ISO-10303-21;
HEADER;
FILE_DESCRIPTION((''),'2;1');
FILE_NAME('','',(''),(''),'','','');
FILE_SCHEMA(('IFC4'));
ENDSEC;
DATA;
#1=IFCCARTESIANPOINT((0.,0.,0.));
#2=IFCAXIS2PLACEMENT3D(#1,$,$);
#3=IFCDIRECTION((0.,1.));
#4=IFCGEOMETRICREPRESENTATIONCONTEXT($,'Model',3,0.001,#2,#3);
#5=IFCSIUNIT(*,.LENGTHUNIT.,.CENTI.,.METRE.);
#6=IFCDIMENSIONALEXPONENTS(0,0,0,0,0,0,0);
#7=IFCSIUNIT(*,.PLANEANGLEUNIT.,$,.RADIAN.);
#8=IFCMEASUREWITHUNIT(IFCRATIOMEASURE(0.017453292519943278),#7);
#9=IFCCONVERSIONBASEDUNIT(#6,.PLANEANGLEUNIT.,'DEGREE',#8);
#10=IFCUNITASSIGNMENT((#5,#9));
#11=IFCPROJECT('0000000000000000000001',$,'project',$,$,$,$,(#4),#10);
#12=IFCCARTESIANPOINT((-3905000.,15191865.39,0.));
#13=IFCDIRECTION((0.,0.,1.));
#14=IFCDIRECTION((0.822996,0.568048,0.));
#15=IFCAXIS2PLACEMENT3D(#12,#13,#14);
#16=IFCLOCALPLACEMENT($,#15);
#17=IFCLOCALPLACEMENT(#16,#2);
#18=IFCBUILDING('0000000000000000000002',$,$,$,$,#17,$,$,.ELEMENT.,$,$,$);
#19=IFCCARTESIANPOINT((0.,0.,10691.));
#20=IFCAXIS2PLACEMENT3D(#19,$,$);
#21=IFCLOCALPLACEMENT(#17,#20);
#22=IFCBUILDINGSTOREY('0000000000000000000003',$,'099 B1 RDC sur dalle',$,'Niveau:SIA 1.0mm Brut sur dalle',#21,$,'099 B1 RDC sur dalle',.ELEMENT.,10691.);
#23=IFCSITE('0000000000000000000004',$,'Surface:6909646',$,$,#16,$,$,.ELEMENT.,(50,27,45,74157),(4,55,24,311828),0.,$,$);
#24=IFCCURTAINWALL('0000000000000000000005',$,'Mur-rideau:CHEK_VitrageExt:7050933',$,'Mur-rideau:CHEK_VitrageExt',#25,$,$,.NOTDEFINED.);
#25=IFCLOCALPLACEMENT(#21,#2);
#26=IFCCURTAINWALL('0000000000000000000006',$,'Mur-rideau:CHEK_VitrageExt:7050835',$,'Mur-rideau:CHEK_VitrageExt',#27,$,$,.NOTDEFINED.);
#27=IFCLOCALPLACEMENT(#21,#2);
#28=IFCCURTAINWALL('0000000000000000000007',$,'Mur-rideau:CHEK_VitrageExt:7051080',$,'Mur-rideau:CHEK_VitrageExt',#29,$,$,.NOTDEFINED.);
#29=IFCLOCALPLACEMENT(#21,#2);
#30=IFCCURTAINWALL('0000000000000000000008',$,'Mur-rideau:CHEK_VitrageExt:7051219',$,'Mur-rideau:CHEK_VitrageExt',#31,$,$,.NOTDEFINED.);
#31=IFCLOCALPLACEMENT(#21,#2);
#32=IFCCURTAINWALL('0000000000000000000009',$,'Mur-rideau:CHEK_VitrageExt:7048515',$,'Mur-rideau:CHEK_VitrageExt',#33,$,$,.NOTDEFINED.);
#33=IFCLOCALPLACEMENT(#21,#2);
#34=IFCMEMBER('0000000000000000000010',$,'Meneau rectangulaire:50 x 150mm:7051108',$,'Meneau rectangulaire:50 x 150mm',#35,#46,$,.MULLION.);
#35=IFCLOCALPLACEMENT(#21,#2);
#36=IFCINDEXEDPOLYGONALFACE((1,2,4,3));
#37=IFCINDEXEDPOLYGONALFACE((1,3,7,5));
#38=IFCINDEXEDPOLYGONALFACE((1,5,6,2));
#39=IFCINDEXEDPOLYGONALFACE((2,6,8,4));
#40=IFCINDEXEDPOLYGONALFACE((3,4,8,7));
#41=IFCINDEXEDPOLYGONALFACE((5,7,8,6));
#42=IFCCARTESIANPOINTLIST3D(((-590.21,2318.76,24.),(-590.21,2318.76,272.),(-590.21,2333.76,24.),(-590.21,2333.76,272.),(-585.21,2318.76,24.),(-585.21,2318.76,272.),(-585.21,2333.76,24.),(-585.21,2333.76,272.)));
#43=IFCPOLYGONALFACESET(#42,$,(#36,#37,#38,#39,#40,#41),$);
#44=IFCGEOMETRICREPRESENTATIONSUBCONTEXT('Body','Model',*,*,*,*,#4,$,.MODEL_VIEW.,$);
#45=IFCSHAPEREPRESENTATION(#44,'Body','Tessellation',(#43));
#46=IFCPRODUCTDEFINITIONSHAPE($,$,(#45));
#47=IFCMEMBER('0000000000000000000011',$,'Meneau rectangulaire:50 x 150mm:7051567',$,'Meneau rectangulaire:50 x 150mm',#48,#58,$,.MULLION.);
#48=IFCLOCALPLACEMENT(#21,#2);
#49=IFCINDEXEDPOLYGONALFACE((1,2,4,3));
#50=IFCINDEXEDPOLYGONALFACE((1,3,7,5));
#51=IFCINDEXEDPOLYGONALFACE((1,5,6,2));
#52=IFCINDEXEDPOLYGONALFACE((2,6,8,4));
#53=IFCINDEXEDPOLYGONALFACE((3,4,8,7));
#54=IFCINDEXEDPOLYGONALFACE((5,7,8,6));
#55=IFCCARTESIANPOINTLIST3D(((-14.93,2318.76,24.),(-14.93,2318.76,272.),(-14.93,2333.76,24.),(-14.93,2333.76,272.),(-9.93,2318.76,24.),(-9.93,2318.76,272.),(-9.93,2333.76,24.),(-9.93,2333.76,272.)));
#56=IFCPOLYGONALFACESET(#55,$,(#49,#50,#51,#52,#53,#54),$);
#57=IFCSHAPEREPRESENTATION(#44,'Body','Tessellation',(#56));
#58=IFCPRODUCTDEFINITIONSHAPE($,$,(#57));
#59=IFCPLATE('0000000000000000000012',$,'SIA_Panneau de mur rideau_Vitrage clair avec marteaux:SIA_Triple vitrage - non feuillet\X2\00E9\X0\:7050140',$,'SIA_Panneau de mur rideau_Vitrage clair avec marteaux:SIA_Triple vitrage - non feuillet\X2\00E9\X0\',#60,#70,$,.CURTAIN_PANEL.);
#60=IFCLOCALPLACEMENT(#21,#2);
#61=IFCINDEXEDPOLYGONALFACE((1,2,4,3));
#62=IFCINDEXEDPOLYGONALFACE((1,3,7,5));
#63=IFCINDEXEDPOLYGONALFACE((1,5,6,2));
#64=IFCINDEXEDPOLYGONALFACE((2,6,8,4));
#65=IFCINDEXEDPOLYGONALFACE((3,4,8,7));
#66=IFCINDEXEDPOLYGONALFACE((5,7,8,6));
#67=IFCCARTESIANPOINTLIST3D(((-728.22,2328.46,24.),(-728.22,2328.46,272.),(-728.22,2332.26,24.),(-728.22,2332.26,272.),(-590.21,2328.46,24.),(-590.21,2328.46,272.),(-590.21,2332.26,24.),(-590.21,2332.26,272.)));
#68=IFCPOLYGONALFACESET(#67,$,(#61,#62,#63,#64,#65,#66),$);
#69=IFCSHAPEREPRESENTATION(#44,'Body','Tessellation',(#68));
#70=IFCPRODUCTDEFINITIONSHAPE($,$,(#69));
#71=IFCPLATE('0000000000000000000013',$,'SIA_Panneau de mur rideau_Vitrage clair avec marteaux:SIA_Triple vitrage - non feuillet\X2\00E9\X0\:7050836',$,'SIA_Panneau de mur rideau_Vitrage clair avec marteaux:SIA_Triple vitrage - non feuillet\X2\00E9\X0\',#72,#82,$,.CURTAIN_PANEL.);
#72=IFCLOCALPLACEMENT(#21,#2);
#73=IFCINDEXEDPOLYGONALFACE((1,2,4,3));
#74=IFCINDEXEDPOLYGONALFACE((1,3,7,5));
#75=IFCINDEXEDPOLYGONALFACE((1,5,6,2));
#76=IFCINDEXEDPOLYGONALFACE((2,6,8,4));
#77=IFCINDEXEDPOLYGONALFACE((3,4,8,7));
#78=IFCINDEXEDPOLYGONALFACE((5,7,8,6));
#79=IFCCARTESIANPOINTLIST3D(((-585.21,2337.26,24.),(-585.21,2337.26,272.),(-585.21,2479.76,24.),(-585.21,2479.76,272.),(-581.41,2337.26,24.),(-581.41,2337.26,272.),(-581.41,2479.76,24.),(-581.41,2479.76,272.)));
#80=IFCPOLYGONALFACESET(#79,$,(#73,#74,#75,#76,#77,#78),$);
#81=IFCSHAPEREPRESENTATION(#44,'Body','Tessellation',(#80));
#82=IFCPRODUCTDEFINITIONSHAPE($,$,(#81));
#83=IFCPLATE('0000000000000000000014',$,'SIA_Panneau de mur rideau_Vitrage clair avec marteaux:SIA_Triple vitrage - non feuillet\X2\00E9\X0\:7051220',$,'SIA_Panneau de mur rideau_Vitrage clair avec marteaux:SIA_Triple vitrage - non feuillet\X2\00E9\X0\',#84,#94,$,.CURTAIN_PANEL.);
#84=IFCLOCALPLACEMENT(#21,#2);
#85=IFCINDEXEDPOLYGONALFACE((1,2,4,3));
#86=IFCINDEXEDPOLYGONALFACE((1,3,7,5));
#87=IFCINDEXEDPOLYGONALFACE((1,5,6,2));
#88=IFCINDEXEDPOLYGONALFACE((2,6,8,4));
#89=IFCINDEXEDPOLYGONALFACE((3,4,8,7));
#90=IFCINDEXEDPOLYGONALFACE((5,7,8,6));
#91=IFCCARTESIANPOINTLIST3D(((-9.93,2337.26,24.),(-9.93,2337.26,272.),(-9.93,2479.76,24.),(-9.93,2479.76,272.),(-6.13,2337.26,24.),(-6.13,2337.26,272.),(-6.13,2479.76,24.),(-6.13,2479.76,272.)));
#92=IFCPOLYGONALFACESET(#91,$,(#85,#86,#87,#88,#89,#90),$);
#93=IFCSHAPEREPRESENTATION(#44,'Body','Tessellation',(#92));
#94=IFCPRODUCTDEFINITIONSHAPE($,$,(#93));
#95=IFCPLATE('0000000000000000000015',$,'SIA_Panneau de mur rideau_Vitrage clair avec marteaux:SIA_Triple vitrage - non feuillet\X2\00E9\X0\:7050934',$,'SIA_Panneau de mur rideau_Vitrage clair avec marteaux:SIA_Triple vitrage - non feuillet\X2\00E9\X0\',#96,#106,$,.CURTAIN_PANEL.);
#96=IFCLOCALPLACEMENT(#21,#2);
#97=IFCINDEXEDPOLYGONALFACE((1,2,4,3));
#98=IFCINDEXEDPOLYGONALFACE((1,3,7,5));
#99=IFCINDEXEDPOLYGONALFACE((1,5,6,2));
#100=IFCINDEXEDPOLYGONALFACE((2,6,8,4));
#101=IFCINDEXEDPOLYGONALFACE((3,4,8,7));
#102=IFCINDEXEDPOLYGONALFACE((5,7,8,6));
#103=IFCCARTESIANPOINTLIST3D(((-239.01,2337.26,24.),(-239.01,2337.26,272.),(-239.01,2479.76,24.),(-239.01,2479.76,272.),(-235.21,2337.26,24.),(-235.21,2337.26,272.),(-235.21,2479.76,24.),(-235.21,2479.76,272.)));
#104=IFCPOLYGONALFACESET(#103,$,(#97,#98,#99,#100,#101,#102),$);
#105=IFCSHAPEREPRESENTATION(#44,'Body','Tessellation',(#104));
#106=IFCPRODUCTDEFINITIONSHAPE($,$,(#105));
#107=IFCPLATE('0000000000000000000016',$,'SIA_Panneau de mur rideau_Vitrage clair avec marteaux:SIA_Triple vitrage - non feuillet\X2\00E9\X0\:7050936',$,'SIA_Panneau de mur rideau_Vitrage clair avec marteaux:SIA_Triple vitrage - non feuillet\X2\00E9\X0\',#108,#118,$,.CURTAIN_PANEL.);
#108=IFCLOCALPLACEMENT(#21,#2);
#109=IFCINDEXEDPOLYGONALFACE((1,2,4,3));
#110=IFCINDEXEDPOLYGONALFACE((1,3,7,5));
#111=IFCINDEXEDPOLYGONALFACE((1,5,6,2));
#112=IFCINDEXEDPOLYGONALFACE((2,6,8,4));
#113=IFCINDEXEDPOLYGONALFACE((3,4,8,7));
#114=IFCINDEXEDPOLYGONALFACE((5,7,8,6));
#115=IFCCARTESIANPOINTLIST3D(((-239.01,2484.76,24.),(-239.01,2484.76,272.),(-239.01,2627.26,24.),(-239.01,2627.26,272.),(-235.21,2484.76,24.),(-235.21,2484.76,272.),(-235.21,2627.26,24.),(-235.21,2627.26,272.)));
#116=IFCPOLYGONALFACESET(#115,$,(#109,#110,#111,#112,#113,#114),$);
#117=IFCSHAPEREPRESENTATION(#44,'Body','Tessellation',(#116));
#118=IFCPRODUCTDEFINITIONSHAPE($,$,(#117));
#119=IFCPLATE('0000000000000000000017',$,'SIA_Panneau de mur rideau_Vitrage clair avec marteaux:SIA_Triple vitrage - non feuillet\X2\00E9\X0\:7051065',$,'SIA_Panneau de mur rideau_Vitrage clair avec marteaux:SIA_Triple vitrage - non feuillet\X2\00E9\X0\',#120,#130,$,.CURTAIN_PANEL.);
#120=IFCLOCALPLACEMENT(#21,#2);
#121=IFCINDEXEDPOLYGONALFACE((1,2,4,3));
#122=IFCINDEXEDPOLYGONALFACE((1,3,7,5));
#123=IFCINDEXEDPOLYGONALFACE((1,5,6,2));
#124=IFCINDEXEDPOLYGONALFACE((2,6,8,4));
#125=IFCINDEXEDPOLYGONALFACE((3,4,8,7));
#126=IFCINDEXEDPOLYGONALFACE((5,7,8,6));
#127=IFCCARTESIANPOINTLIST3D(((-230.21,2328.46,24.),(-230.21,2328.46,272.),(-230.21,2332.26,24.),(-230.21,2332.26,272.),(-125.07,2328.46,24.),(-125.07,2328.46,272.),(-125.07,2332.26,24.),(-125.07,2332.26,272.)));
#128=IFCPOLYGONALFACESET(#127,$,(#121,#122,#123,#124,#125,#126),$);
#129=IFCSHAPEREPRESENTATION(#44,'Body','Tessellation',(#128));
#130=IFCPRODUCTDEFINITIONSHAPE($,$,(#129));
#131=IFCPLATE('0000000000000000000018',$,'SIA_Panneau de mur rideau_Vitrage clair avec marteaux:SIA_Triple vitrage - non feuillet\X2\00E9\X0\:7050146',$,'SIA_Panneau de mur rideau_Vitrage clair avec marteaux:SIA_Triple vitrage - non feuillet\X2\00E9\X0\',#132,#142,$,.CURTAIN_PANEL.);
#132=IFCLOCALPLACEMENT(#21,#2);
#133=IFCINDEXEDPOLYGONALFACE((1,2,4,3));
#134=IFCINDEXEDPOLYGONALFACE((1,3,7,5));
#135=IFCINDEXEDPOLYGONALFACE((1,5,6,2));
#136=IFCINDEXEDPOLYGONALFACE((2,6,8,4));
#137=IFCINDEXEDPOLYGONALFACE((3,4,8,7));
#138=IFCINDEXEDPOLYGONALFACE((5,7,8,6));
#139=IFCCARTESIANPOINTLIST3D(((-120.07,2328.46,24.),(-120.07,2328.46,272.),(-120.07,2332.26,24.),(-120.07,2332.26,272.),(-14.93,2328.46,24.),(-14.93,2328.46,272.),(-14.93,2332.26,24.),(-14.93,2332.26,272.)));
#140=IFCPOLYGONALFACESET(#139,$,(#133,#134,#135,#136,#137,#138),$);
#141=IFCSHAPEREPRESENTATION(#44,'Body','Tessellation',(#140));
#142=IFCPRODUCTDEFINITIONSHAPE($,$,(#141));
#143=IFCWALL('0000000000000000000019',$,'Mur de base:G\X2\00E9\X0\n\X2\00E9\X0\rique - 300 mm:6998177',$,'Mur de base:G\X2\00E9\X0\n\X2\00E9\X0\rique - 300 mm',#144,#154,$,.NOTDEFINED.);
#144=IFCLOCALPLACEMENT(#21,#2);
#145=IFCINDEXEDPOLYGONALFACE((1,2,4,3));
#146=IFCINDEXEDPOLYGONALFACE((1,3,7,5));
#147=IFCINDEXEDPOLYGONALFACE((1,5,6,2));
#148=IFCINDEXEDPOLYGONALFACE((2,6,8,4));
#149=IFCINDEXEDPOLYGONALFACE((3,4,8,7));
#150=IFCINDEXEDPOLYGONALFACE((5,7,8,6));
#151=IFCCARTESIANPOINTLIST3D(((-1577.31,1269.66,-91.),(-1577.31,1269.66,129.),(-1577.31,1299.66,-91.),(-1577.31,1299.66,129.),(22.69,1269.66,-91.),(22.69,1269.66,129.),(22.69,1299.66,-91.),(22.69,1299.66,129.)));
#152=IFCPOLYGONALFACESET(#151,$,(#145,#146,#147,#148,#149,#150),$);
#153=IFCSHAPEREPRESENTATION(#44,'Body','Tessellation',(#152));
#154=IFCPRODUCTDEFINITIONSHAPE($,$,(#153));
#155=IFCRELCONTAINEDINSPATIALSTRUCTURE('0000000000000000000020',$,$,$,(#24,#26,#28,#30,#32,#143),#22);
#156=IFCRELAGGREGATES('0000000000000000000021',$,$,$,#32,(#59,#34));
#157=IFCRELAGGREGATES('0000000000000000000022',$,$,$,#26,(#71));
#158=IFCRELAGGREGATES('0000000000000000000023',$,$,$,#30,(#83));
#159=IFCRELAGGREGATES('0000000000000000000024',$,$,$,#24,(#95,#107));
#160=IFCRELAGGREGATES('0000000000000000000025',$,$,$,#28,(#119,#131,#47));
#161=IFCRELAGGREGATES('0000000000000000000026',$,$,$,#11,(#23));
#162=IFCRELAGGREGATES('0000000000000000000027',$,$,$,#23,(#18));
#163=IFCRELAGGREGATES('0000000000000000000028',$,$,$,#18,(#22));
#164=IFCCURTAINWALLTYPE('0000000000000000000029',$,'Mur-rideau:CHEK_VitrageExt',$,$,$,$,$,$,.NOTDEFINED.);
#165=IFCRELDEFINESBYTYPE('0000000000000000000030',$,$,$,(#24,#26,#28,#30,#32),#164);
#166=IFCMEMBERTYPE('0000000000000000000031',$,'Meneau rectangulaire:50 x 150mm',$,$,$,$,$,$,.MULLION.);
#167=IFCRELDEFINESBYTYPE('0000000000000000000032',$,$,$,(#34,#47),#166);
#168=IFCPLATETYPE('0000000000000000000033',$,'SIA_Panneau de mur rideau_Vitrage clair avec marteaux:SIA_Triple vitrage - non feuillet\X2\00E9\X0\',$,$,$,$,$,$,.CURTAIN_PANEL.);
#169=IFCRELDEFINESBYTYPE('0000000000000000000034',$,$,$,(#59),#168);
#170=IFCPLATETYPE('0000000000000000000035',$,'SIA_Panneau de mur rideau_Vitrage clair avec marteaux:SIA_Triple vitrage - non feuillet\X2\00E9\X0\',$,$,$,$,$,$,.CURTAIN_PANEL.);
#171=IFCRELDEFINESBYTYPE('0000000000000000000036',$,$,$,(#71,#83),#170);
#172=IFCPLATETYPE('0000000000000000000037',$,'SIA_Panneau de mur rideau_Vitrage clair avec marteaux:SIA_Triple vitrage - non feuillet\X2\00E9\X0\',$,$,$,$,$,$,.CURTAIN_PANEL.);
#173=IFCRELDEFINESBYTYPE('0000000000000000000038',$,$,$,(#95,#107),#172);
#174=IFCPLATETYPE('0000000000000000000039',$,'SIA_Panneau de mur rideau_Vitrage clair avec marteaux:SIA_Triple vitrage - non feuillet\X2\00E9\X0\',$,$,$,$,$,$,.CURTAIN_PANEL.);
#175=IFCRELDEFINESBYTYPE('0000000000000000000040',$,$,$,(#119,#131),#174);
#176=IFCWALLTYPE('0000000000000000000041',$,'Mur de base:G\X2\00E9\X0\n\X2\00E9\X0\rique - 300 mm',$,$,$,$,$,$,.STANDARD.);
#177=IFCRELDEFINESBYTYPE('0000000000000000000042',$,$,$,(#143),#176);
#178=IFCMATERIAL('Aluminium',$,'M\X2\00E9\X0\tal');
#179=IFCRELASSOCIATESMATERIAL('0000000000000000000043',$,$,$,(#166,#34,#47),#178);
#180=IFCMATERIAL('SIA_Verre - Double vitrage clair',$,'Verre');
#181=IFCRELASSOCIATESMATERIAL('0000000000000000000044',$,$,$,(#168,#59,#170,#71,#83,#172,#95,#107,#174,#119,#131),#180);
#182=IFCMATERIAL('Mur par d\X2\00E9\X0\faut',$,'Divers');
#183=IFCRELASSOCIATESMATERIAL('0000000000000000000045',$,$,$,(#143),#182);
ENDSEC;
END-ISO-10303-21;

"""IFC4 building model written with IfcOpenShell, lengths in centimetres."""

from ifc_helpers import new_model, entity, si_unit, converted_unit, direction, frame, origin, place, context, subcontext, project, spatial, indexed_curve, outline, extrude, source, transform, mapped, material, type_object, type_shapes, element, aggregate, save


model = new_model("IFC4")

# Units and contexts
model_context = context("Model", 3, precision=0.001, world=origin(), true_north=direction((0.0, 1.0)))
body_context = subcontext(model_context, "Body", "Model", "MODEL_VIEW")
ifc_project = project(units=[si_unit("LENGTHUNIT", "METRE", prefix="CENTI"), converted_unit("PLANEANGLEUNIT", "DEGREE", entity("IfcRatioMeasure", 0.017453292519943278), si_unit("PLANEANGLEUNIT", "RADIAN"), dimensions=[0, 0, 0, 0, 0, 0, 0])], contexts=[model_context])

# Site, building, storey
site_placement = place(None, frame((-3905000.0, 15191865.39, 0.0), z_axis=(0.0, 0.0, 1.0), x_axis=(0.822996, 0.568048, 0.0)))
site = spatial("IfcSite", under=ifc_project, at=site_placement, Name="Surface:6909646", CompositionType="ELEMENT", RefLatitude=(50, 27, 45, 74157), RefLongitude=(4, 55, 24, 311828), RefElevation=0.0)
building_placement = place(site_placement, origin())
building = spatial("IfcBuilding", under=site, at=building_placement, CompositionType="ELEMENT")
storey_placement = place(building_placement, frame((0.0, 0.0, 10691.0)))
storey = spatial("IfcBuildingStorey", under=building, at=storey_placement, Name="099 B1 RDC sur dalle", ObjectType="Niveau:SIA 1.0mm Brut sur dalle", LongName="099 B1 RDC sur dalle", CompositionType="ELEMENT", Elevation=10691.0)

# Curtain wall
curtain_wall_type = type_object("IfcCurtainWallType", Name="Mur-rideau:CHEK_VitrageExt", PredefinedType="NOTDEFINED")
curtain_wall_1_placement = place(storey_placement, frame((0.0, 0.0, -10691.0)))
curtain_wall_1 = element("IfcCurtainWall", 1, at=curtain_wall_1_placement, inside=storey, type_object=curtain_wall_type, Name="Mur-rideau:CHEK_VitrageExt:7050933", ObjectType="Mur-rideau:CHEK_VitrageExt", PredefinedType="NOTDEFINED")
ifc_material_1 = material(Name="Aluminium", Category="Métal")

# Curtain walls
curtain_wall_2_placement = place(storey_placement, frame((0.0, 0.0, -10691.0)))
curtain_wall_2 = element("IfcCurtainWall", 2, at=curtain_wall_2_placement, inside=storey, type_object=curtain_wall_type, Name="Mur-rideau:CHEK_VitrageExt:7050835", ObjectType="Mur-rideau:CHEK_VitrageExt", PredefinedType="NOTDEFINED")
curtain_wall_3_placement = place(storey_placement, frame((0.0, 0.0, -10691.0)))
curtain_wall_3 = element("IfcCurtainWall", 3, at=curtain_wall_3_placement, inside=storey, type_object=curtain_wall_type, Name="Mur-rideau:CHEK_VitrageExt:7051080", ObjectType="Mur-rideau:CHEK_VitrageExt", PredefinedType="NOTDEFINED")
curtain_wall_4_placement = place(storey_placement, frame((0.0, 0.0, -10691.0)))
curtain_wall_4 = element("IfcCurtainWall", 4, at=curtain_wall_4_placement, inside=storey, type_object=curtain_wall_type, Name="Mur-rideau:CHEK_VitrageExt:7051219", ObjectType="Mur-rideau:CHEK_VitrageExt", PredefinedType="NOTDEFINED")

# Curtain wall, member
curtain_wall_5_placement = place(storey_placement, frame((0.0, 0.0, -10691.0)))
curtain_wall_5 = element("IfcCurtainWall", 5, at=curtain_wall_5_placement, inside=storey, type_object=curtain_wall_type, Name="Mur-rideau:CHEK_VitrageExt:7048515", ObjectType="Mur-rideau:CHEK_VitrageExt", PredefinedType="NOTDEFINED")
member_type_1 = type_object("IfcMemberType", Name="Meneau rectangulaire:50 x 150mm", PredefinedType="MULLION", material=ifc_material_1)
shared_shape_1 = source(origin(), body_context, "Body", "SweptSolid", [
    extrude(outline(indexed_curve([(-7.5, -2.5), (7.5, -2.5), (7.5, 2.5), (-7.5, 2.5), (-7.5, -2.5)], self_intersect=False)), frame((-2.5, 6.0, -248.0), z_axis=(0.0, 0.0, 1.0), x_axis=(0.0, -1.0, 0.0)), (0.0, 0.0, 1.0), 248.0),
])
type_shapes(member_type_1, [shared_shape_1])
member_1_placement = place(curtain_wall_5_placement, frame((-585.21, 2332.26, 10715.0), z_axis=(0.0, 0.0, -1.0), x_axis=(1.0, 0.0, 0.0)))
member_1 = element("IfcMember", 6, at=member_1_placement, type_object=member_type_1, material=ifc_material_1, Name="Meneau rectangulaire:50 x 150mm:7051108", ObjectType="Meneau rectangulaire:50 x 150mm", PredefinedType="MULLION", context=body_context, shape_type="MappedRepresentation", body=[
    mapped(shared_shape_1, transform((0.0, 0.0, 0.0), scale=1.0)),
])

# Member
member_2_placement = place(curtain_wall_3_placement, frame((-9.93, 2332.26, 10715.0), z_axis=(0.0, 0.0, -1.0), x_axis=(1.0, 0.0, 0.0)))
member_2 = element("IfcMember", 7, at=member_2_placement, type_object=member_type_1, material=ifc_material_1, Name="Meneau rectangulaire:50 x 150mm:7051567", ObjectType="Meneau rectangulaire:50 x 150mm", PredefinedType="MULLION", context=body_context, shape_type="MappedRepresentation", body=[
    mapped(shared_shape_1, transform((0.0, 0.0, 0.0), scale=1.0)),
])

# Plates
ifc_material_2 = material(Name="SIA_Verre - Double vitrage clair", Category="Verre")
plate_type_1 = type_object("IfcPlateType", Name="SIA_Panneau de mur rideau_Vitrage clair avec marteaux:SIA_Triple vitrage - non feuilleté", PredefinedType="CURTAIN_PANEL", material=ifc_material_2)
shared_shape_2 = source(origin(), body_context, "Body", "SweptSolid", [
    extrude(outline(indexed_curve([(-1.9, -69.0), (1.9, -69.0), (1.9, 69.0), (-1.9, 69.0), (-1.9, -69.0)], self_intersect=False)), frame((0.0, -1.9, 0.0), z_axis=(0.0, 0.0, 1.0), x_axis=(0.0, 1.0, 0.0)), (0.0, 0.0, 1.0), 248.0),
])
type_shapes(plate_type_1, [shared_shape_2])
plate_1_placement = place(curtain_wall_5_placement, frame((-659.21, 2332.26, 10715.0)))
plate_1 = element("IfcPlate", 8, at=plate_1_placement, type_object=plate_type_1, material=ifc_material_2, Name="SIA_Panneau de mur rideau_Vitrage clair avec marteaux:SIA_Triple vitrage - non feuilleté:7050140", ObjectType="SIA_Panneau de mur rideau_Vitrage clair avec marteaux:SIA_Triple vitrage - non feuilleté", PredefinedType="CURTAIN_PANEL", context=body_context, shape_type="MappedRepresentation", body=[
    mapped(shared_shape_2, transform((0.0, 0.0, 0.0), scale=1.0)),
])
aggregate(curtain_wall_5, [plate_1, member_1])
plate_type_2 = type_object("IfcPlateType", Name="SIA_Panneau de mur rideau_Vitrage clair avec marteaux:SIA_Triple vitrage - non feuilleté", PredefinedType="CURTAIN_PANEL", material=ifc_material_2)
shared_shape_3 = source(origin(), body_context, "Body", "SweptSolid", [
    extrude(outline(indexed_curve([(-1.9, -71.25), (1.9, -71.25), (1.9, 71.25), (-1.9, 71.25), (-1.9, -71.25)], self_intersect=False)), frame((0.0, -1.9, 0.0), z_axis=(0.0, 0.0, 1.0), x_axis=(0.0, 1.0, 0.0)), (0.0, 0.0, 1.0), 248.0),
])
type_shapes(plate_type_2, [shared_shape_3])
plate_2_placement = place(curtain_wall_2_placement, frame((-585.21, 2408.51, 10715.0), z_axis=(0.0, 0.0, 1.0), x_axis=(0.0, 1.0, 0.0)))
plate_2 = element("IfcPlate", 9, at=plate_2_placement, type_object=plate_type_2, material=ifc_material_2, Name="SIA_Panneau de mur rideau_Vitrage clair avec marteaux:SIA_Triple vitrage - non feuilleté:7050836", ObjectType="SIA_Panneau de mur rideau_Vitrage clair avec marteaux:SIA_Triple vitrage - non feuilleté", PredefinedType="CURTAIN_PANEL", context=body_context, shape_type="MappedRepresentation", body=[
    mapped(shared_shape_3, transform((0.0, 0.0, 0.0), scale=1.0)),
])
aggregate(curtain_wall_2, [plate_2])
plate_3_placement = place(curtain_wall_4_placement, frame((-9.93, 2408.51, 10715.0), z_axis=(0.0, 0.0, 1.0), x_axis=(0.0, 1.0, 0.0)))
plate_3 = element("IfcPlate", 10, at=plate_3_placement, type_object=plate_type_2, material=ifc_material_2, Name="SIA_Panneau de mur rideau_Vitrage clair avec marteaux:SIA_Triple vitrage - non feuilleté:7051220", ObjectType="SIA_Panneau de mur rideau_Vitrage clair avec marteaux:SIA_Triple vitrage - non feuilleté", PredefinedType="CURTAIN_PANEL", context=body_context, shape_type="MappedRepresentation", body=[
    mapped(shared_shape_3, transform((0.0, 0.0, 0.0), scale=1.0)),
])
aggregate(curtain_wall_4, [plate_3])
plate_type_3 = type_object("IfcPlateType", Name="SIA_Panneau de mur rideau_Vitrage clair avec marteaux:SIA_Triple vitrage - non feuilleté", PredefinedType="CURTAIN_PANEL", material=ifc_material_2)
shared_shape_4 = source(origin(), body_context, "Body", "SweptSolid", [
    extrude(outline(indexed_curve([(-71.25, -1.9), (71.25, -1.9), (71.25, 1.9), (-71.25, 1.9), (-71.25, -1.9)], self_intersect=False)), frame((0.0, 1.9, 0.0), z_axis=(0.0, 0.0, 1.0), x_axis=(-1.0, 0.0, 0.0)), (0.0, 0.0, 1.0), 248.0),
])
type_shapes(plate_type_3, [shared_shape_4])
plate_4_placement = place(curtain_wall_1_placement, frame((-235.21, 2408.51, 10715.0), z_axis=(0.0, 0.0, 1.0), x_axis=(0.0, 1.0, 0.0)))
plate_4 = element("IfcPlate", 11, at=plate_4_placement, type_object=plate_type_3, material=ifc_material_2, Name="SIA_Panneau de mur rideau_Vitrage clair avec marteaux:SIA_Triple vitrage - non feuilleté:7050934", ObjectType="SIA_Panneau de mur rideau_Vitrage clair avec marteaux:SIA_Triple vitrage - non feuilleté", PredefinedType="CURTAIN_PANEL", context=body_context, shape_type="MappedRepresentation", body=[
    mapped(shared_shape_4, transform((0.0, 0.0, 0.0), scale=1.0)),
])
plate_5_placement = place(curtain_wall_1_placement, frame((-235.21, 2556.01, 10715.0), z_axis=(0.0, 0.0, 1.0), x_axis=(0.0, 1.0, 0.0)))
plate_5 = element("IfcPlate", 12, at=plate_5_placement, type_object=plate_type_3, material=ifc_material_2, Name="SIA_Panneau de mur rideau_Vitrage clair avec marteaux:SIA_Triple vitrage - non feuilleté:7050936", ObjectType="SIA_Panneau de mur rideau_Vitrage clair avec marteaux:SIA_Triple vitrage - non feuilleté", PredefinedType="CURTAIN_PANEL", context=body_context, shape_type="MappedRepresentation", body=[
    mapped(shared_shape_4, transform((0.0, 0.0, 0.0), scale=1.0)),
])
aggregate(curtain_wall_1, [plate_4, plate_5])
plate_type_4 = type_object("IfcPlateType", Name="SIA_Panneau de mur rideau_Vitrage clair avec marteaux:SIA_Triple vitrage - non feuilleté", PredefinedType="CURTAIN_PANEL", material=ifc_material_2)
shared_shape_5 = source(origin(), body_context, "Body", "SweptSolid", [
    extrude(outline(indexed_curve([(-1.9, -52.57), (1.9, -52.57), (1.9, 52.57), (-1.9, 52.57), (-1.9, -52.57)], self_intersect=False)), frame((0.0, -1.9, 0.0), z_axis=(0.0, 0.0, 1.0), x_axis=(0.0, 1.0, 0.0)), (0.0, 0.0, 1.0), 248.0),
])
type_shapes(plate_type_4, [shared_shape_5])
plate_6_placement = place(curtain_wall_3_placement, frame((-177.64, 2332.26, 10715.0)))
plate_6 = element("IfcPlate", 13, at=plate_6_placement, type_object=plate_type_4, material=ifc_material_2, Name="SIA_Panneau de mur rideau_Vitrage clair avec marteaux:SIA_Triple vitrage - non feuilleté:7051065", ObjectType="SIA_Panneau de mur rideau_Vitrage clair avec marteaux:SIA_Triple vitrage - non feuilleté", PredefinedType="CURTAIN_PANEL", context=body_context, shape_type="MappedRepresentation", body=[
    mapped(shared_shape_5, transform((0.0, 0.0, 0.0), scale=1.0)),
])
plate_7_placement = place(curtain_wall_3_placement, frame((-67.5, 2332.26, 10715.0)))
plate_7 = element("IfcPlate", 14, at=plate_7_placement, type_object=plate_type_4, material=ifc_material_2, Name="SIA_Panneau de mur rideau_Vitrage clair avec marteaux:SIA_Triple vitrage - non feuilleté:7050146", ObjectType="SIA_Panneau de mur rideau_Vitrage clair avec marteaux:SIA_Triple vitrage - non feuilleté", PredefinedType="CURTAIN_PANEL", context=body_context, shape_type="MappedRepresentation", body=[
    mapped(shared_shape_5, transform((0.0, 0.0, 0.0), scale=1.0)),
])
aggregate(curtain_wall_3, [plate_6, plate_7, member_2])

# Wall
ifc_material_3 = material(Name="Mur par défaut", Category="Divers")
wall_type_1 = type_object("IfcWallType", Name="Mur de base:Générique - 300 mm", PredefinedType="STANDARD")
wall_1_placement = place(storey_placement, frame((22.69, 1284.66, -91.0), z_axis=(0.0, 0.0, 1.0), x_axis=(-1.0, 0.0, 0.0)))
element("IfcWall", 15, at=wall_1_placement, inside=storey, type_object=wall_type_1, material=ifc_material_3, Name="Mur de base:Générique - 300 mm:6998177", ObjectType="Mur de base:Générique - 300 mm", PredefinedType="NOTDEFINED", context=body_context, shape_type="SweptSolid", body=[
    extrude(outline(indexed_curve([(1600.0, 15.0), (0.0, 15.0), (0.0, -15.0), (1600.0, -15.0), (1600.0, 15.0)], self_intersect=False)), origin(), (0.0, 0.0, 1.0), 220.0),
])

save(model, "model.ifc")
